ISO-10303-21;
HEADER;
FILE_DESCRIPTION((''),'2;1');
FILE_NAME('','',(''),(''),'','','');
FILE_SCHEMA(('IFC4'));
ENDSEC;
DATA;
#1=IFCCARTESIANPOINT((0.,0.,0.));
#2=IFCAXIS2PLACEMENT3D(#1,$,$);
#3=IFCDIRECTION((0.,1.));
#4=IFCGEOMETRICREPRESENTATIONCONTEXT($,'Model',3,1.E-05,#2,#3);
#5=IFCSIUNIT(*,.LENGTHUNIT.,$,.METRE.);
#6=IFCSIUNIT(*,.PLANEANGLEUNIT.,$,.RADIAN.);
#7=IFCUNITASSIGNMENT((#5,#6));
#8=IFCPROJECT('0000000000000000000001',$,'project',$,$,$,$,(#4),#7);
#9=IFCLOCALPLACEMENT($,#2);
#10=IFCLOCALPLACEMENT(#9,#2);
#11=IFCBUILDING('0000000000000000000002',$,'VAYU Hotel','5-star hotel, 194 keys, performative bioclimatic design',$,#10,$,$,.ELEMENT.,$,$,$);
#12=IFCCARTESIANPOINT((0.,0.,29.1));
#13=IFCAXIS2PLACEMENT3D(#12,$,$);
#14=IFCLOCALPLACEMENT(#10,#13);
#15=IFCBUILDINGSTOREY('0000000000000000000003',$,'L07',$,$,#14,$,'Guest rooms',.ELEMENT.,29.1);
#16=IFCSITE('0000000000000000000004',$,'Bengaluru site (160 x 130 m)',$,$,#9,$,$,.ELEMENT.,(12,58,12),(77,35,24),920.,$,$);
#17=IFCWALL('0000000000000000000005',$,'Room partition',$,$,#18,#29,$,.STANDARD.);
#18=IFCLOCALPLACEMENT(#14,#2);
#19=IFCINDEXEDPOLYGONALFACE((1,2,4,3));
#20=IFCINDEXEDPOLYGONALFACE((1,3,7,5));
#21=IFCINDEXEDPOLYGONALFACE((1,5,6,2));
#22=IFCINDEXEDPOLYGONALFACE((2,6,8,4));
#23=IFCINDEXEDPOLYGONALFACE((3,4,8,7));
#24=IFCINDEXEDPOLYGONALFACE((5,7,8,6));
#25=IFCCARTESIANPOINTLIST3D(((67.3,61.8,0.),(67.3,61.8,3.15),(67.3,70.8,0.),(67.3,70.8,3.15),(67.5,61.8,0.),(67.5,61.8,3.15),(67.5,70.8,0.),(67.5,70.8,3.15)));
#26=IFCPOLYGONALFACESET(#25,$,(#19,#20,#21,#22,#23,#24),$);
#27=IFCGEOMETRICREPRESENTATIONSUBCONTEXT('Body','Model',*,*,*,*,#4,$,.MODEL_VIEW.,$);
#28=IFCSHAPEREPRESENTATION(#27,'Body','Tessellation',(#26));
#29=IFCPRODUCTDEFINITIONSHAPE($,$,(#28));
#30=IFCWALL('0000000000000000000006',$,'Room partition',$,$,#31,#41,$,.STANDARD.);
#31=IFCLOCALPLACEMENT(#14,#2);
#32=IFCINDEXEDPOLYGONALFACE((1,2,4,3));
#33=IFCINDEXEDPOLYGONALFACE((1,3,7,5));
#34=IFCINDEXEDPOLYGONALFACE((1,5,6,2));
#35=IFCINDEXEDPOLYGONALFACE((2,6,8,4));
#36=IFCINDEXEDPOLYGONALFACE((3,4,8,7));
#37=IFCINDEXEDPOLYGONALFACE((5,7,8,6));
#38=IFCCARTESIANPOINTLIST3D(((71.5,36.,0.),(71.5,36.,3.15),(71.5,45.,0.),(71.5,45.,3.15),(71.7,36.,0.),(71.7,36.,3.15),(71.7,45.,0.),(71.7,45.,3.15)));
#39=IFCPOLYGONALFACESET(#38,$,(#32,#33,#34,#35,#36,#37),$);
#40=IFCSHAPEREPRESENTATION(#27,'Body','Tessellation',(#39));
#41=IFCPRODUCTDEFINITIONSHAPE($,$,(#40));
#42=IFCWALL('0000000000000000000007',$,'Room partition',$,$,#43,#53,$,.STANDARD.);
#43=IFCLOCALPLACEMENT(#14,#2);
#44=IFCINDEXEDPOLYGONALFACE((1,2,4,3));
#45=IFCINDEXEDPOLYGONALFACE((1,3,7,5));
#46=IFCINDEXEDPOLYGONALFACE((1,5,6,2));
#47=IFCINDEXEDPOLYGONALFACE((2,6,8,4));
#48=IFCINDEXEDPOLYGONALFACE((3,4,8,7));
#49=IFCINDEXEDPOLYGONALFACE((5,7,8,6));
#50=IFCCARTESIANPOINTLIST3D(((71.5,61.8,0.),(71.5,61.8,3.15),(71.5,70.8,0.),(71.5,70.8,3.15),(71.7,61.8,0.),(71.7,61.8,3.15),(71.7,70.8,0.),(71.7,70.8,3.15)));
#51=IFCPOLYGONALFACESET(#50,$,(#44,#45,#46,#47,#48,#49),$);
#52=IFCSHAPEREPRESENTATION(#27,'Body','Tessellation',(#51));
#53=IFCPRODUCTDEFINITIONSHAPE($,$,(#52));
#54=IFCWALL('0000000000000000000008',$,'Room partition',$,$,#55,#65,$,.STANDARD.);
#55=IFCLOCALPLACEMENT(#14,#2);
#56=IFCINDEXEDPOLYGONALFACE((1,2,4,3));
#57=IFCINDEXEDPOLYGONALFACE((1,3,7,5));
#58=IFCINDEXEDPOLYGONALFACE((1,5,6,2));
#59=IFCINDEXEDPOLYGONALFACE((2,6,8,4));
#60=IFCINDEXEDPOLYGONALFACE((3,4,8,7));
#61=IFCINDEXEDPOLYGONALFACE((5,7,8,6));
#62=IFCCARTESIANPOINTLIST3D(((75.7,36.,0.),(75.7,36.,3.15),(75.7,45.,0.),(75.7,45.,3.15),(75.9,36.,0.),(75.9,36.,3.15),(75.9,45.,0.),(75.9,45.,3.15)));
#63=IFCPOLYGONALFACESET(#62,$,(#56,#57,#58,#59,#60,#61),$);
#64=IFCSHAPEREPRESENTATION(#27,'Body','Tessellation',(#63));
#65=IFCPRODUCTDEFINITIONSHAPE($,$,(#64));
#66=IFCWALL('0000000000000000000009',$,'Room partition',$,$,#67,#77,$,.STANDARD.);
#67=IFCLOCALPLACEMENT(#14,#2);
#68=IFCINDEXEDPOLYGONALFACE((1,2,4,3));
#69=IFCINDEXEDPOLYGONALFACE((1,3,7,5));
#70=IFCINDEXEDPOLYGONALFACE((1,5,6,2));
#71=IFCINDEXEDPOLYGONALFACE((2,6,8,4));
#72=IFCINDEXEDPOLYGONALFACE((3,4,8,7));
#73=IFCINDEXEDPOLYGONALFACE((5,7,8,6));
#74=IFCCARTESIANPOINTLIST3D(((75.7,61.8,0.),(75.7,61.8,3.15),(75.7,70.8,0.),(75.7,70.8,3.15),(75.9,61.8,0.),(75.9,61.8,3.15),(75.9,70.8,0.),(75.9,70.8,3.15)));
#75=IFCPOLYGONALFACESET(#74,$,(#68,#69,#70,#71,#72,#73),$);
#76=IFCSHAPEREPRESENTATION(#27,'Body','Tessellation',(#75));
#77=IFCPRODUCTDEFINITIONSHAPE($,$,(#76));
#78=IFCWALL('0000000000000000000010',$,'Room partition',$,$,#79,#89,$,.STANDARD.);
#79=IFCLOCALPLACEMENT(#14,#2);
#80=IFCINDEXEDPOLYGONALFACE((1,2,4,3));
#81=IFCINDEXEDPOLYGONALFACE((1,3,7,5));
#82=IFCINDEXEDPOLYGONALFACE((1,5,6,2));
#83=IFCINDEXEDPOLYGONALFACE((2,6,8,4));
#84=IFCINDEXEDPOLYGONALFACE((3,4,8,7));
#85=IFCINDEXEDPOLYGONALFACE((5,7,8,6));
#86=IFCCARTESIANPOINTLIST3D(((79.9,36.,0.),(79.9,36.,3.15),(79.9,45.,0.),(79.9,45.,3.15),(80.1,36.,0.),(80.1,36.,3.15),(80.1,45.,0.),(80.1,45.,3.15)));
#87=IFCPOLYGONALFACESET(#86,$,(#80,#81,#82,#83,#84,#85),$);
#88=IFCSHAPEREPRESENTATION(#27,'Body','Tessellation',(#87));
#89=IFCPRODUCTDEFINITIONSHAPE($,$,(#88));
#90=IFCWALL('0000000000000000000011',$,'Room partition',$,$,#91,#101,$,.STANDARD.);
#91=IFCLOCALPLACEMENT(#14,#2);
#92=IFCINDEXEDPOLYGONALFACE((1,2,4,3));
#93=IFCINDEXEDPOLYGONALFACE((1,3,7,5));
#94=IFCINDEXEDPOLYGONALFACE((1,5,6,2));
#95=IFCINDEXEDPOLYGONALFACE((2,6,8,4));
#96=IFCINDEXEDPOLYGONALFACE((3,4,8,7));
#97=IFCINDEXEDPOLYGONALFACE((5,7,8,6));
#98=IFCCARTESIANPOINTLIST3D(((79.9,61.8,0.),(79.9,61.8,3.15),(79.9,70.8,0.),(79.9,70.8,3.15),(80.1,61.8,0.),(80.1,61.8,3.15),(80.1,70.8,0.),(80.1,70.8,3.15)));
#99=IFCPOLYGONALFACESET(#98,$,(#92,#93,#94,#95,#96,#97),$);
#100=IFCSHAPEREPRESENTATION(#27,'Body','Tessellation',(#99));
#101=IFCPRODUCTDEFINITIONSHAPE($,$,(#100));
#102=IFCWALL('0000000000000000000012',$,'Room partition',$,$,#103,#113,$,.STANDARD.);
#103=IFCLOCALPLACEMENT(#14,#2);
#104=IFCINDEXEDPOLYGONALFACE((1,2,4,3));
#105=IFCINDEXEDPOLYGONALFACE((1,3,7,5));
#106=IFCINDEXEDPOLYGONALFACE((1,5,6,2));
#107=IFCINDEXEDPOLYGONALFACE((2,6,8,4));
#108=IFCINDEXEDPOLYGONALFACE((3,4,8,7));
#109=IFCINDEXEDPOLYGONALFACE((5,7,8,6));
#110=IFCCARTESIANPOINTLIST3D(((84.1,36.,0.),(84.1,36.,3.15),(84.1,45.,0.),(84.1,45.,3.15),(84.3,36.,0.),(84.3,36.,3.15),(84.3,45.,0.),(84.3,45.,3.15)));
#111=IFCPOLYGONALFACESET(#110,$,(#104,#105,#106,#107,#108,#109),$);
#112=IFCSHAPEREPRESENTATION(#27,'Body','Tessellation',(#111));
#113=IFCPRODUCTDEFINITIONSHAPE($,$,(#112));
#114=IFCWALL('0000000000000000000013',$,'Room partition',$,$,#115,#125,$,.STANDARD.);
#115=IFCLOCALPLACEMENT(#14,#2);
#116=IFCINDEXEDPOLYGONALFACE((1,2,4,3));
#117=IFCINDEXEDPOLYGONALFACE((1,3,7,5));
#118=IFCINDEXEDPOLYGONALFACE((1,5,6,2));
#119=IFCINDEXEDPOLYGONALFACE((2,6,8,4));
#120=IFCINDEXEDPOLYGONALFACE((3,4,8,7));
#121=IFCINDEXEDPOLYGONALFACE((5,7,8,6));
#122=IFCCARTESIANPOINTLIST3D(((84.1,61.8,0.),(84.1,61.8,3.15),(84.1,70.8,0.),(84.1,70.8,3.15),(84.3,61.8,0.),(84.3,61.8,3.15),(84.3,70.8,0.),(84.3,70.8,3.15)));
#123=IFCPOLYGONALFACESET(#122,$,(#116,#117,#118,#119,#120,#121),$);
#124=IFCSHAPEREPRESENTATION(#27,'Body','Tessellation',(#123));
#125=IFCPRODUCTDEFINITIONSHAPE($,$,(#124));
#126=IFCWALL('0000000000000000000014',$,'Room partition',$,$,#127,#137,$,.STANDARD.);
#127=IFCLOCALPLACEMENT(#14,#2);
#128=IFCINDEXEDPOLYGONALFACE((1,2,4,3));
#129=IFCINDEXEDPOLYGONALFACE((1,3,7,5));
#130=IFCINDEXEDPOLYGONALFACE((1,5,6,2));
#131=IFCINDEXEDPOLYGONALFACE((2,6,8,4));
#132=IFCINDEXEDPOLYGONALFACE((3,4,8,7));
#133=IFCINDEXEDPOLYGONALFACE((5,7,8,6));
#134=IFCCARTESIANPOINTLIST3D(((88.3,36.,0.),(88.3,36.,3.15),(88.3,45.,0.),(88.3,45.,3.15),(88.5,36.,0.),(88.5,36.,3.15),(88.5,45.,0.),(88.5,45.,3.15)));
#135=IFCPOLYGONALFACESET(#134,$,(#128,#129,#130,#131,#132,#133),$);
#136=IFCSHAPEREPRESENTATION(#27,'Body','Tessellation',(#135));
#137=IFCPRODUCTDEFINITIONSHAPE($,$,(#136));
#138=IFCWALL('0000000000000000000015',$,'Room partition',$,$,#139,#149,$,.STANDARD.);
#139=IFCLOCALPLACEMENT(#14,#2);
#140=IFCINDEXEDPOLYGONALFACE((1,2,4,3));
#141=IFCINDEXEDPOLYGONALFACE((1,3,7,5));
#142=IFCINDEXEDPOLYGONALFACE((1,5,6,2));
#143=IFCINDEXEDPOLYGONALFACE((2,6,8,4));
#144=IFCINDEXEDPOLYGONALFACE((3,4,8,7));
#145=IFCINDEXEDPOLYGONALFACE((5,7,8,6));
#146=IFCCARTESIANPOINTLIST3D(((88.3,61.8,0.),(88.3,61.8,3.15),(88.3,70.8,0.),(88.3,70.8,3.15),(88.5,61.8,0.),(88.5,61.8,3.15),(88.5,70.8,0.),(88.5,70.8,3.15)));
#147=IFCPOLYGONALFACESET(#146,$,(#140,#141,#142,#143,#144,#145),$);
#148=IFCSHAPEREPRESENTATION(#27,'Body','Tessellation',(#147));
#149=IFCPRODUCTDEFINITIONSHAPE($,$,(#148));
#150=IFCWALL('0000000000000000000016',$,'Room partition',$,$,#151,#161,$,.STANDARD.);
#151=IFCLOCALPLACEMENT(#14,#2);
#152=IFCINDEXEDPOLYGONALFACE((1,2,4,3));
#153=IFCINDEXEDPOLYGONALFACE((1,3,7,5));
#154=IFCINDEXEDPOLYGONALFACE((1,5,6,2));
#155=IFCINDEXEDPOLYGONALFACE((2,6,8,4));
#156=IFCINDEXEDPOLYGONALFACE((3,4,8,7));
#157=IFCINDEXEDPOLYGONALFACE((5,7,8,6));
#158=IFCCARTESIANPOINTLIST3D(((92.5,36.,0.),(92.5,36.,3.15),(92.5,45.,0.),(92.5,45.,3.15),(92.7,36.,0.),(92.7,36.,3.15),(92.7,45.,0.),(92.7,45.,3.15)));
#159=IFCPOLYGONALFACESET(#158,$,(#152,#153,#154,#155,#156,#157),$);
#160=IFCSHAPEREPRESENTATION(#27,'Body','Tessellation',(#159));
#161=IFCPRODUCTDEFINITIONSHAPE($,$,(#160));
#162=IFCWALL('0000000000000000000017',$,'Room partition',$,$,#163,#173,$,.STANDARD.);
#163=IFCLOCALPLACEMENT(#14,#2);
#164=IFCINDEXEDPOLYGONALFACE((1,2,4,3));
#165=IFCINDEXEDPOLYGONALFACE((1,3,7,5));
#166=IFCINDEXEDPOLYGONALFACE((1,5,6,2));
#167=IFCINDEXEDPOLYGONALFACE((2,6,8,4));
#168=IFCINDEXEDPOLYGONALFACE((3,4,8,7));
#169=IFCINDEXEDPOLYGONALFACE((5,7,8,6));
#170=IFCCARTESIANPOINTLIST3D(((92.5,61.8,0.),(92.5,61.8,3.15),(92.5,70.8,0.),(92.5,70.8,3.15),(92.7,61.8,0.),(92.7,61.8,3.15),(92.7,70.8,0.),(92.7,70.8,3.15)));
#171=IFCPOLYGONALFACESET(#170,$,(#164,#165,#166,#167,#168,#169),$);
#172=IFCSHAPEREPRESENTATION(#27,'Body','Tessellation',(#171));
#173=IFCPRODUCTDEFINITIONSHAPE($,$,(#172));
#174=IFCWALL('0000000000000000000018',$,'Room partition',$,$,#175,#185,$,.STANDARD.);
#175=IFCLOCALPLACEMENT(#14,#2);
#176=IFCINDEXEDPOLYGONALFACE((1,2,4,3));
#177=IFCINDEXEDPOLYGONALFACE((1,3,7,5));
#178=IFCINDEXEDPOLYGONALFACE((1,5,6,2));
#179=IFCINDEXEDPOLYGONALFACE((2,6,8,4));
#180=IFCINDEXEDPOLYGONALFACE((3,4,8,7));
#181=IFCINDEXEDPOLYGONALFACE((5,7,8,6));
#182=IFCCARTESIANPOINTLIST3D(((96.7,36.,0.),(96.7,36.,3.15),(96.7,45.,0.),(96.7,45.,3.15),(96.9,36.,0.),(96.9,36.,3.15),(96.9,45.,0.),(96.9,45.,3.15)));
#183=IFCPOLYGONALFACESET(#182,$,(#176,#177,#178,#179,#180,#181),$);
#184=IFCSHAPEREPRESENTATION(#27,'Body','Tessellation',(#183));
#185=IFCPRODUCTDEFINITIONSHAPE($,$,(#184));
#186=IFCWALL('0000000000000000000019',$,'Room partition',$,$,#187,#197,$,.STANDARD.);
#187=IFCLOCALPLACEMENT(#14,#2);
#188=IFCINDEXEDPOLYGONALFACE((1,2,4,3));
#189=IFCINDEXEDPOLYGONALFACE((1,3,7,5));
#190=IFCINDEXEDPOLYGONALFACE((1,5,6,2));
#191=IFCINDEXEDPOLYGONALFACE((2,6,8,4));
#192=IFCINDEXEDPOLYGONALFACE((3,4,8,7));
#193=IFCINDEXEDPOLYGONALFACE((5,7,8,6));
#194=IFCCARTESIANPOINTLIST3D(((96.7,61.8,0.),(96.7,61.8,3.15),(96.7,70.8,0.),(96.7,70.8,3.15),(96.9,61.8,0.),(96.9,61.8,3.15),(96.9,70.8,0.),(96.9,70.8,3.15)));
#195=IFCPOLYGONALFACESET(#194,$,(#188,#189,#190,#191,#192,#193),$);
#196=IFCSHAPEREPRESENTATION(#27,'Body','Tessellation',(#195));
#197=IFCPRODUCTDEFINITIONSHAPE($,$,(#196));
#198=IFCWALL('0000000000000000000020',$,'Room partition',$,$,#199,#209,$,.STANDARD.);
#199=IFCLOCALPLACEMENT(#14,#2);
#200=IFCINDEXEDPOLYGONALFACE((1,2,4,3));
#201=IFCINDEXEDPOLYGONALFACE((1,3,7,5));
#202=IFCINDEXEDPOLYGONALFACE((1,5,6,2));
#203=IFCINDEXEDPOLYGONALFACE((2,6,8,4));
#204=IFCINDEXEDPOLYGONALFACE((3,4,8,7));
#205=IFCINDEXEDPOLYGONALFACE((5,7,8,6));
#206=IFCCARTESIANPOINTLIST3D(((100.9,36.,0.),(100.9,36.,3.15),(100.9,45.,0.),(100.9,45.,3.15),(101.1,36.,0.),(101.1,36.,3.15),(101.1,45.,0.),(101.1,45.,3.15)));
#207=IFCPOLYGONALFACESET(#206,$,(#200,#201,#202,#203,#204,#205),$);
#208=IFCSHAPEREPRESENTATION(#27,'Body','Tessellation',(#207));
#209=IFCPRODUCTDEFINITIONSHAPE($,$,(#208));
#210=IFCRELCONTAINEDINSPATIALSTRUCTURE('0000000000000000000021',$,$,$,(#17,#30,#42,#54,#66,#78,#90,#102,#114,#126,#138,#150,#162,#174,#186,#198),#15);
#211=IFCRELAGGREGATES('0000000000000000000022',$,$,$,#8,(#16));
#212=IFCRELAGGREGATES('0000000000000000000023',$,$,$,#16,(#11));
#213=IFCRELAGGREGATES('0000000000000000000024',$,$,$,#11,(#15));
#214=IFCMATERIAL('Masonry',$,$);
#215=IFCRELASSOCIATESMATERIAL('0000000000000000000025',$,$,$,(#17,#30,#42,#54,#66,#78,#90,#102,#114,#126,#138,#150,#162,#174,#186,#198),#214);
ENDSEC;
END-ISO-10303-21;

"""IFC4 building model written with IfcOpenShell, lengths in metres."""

from ifc_helpers import new_model, si_unit, direction, frame, origin, place, context, subcontext, project, spatial, polyline, outline, extrude, material, element, save


model = new_model("IFC4")

# Units and contexts
model_context = context("Model", 3, precision=1e-05, world=origin(), true_north=direction((0.0, 1.0)))
body_context = subcontext(model_context, "Body", "Model", "MODEL_VIEW")
ifc_project = project(units=[si_unit("LENGTHUNIT", "METRE"), si_unit("PLANEANGLEUNIT", "RADIAN")], contexts=[model_context])

# Site, building, storey
site_placement = place(None, origin())
site = spatial("IfcSite", under=ifc_project, at=site_placement, Name="Bengaluru site (160 x 130 m)", CompositionType="ELEMENT", RefLatitude=(12, 58, 12), RefLongitude=(77, 35, 24), RefElevation=920.0)
building_placement = place(site_placement, origin())
building = spatial("IfcBuilding", under=site, at=building_placement, Name="VAYU Hotel", Description="5-star hotel, 194 keys, performative bioclimatic design", CompositionType="ELEMENT")
storey_placement = place(building_placement, frame((0.0, 0.0, 29.1)))
storey = spatial("IfcBuildingStorey", under=building, at=storey_placement, Name="L07", LongName="Guest rooms", CompositionType="ELEMENT", Elevation=29.1)

# Walls
ifc_material_1 = material(Name="Masonry")
wall_1_placement = place(storey_placement, origin())
element("IfcWall", 1, at=wall_1_placement, inside=storey, material=ifc_material_1, Name="Room partition", PredefinedType="STANDARD", context=body_context, shape_type="SweptSolid", body=[
    extrude(outline(polyline([(67.3, 61.8), (67.3, 70.8), (67.5, 70.8), (67.5, 61.8), (67.3, 61.8)])), origin(), (0.0, 0.0, 1.0), 3.15),
])
wall_2_placement = place(storey_placement, origin())
element("IfcWall", 2, at=wall_2_placement, inside=storey, material=ifc_material_1, Name="Room partition", PredefinedType="STANDARD", context=body_context, shape_type="SweptSolid", body=[
    extrude(outline(polyline([(71.5, 36.0), (71.5, 45.0), (71.7, 45.0), (71.7, 36.0), (71.5, 36.0)])), origin(), (0.0, 0.0, 1.0), 3.15),
])
wall_3_placement = place(storey_placement, origin())
element("IfcWall", 3, at=wall_3_placement, inside=storey, material=ifc_material_1, Name="Room partition", PredefinedType="STANDARD", context=body_context, shape_type="SweptSolid", body=[
    extrude(outline(polyline([(71.5, 61.8), (71.5, 70.8), (71.7, 70.8), (71.7, 61.8), (71.5, 61.8)])), origin(), (0.0, 0.0, 1.0), 3.15),
])
wall_4_placement = place(storey_placement, origin())
element("IfcWall", 4, at=wall_4_placement, inside=storey, material=ifc_material_1, Name="Room partition", PredefinedType="STANDARD", context=body_context, shape_type="SweptSolid", body=[
    extrude(outline(polyline([(75.7, 36.0), (75.7, 45.0), (75.9, 45.0), (75.9, 36.0), (75.7, 36.0)])), origin(), (0.0, 0.0, 1.0), 3.15),
])
wall_5_placement = place(storey_placement, origin())
element("IfcWall", 5, at=wall_5_placement, inside=storey, material=ifc_material_1, Name="Room partition", PredefinedType="STANDARD", context=body_context, shape_type="SweptSolid", body=[
    extrude(outline(polyline([(75.7, 61.8), (75.7, 70.8), (75.9, 70.8), (75.9, 61.8), (75.7, 61.8)])), origin(), (0.0, 0.0, 1.0), 3.15),
])
wall_6_placement = place(storey_placement, origin())
element("IfcWall", 6, at=wall_6_placement, inside=storey, material=ifc_material_1, Name="Room partition", PredefinedType="STANDARD", context=body_context, shape_type="SweptSolid", body=[
    extrude(outline(polyline([(79.9, 36.0), (79.9, 45.0), (80.1, 45.0), (80.1, 36.0), (79.9, 36.0)])), origin(), (0.0, 0.0, 1.0), 3.15),
])
wall_7_placement = place(storey_placement, origin())
element("IfcWall", 7, at=wall_7_placement, inside=storey, material=ifc_material_1, Name="Room partition", PredefinedType="STANDARD", context=body_context, shape_type="SweptSolid", body=[
    extrude(outline(polyline([(79.9, 61.8), (79.9, 70.8), (80.1, 70.8), (80.1, 61.8), (79.9, 61.8)])), origin(), (0.0, 0.0, 1.0), 3.15),
])
wall_8_placement = place(storey_placement, origin())
element("IfcWall", 8, at=wall_8_placement, inside=storey, material=ifc_material_1, Name="Room partition", PredefinedType="STANDARD", context=body_context, shape_type="SweptSolid", body=[
    extrude(outline(polyline([(84.1, 36.0), (84.1, 45.0), (84.3, 45.0), (84.3, 36.0), (84.1, 36.0)])), origin(), (0.0, 0.0, 1.0), 3.15),
])
wall_9_placement = place(storey_placement, origin())
element("IfcWall", 9, at=wall_9_placement, inside=storey, material=ifc_material_1, Name="Room partition", PredefinedType="STANDARD", context=body_context, shape_type="SweptSolid", body=[
    extrude(outline(polyline([(84.1, 61.8), (84.1, 70.8), (84.3, 70.8), (84.3, 61.8), (84.1, 61.8)])), origin(), (0.0, 0.0, 1.0), 3.15),
])
wall_10_placement = place(storey_placement, origin())
element("IfcWall", 10, at=wall_10_placement, inside=storey, material=ifc_material_1, Name="Room partition", PredefinedType="STANDARD", context=body_context, shape_type="SweptSolid", body=[
    extrude(outline(polyline([(88.3, 36.0), (88.3, 45.0), (88.5, 45.0), (88.5, 36.0), (88.3, 36.0)])), origin(), (0.0, 0.0, 1.0), 3.15),
])
wall_11_placement = place(storey_placement, origin())
element("IfcWall", 11, at=wall_11_placement, inside=storey, material=ifc_material_1, Name="Room partition", PredefinedType="STANDARD", context=body_context, shape_type="SweptSolid", body=[
    extrude(outline(polyline([(88.3, 61.8), (88.3, 70.8), (88.5, 70.8), (88.5, 61.8), (88.3, 61.8)])), origin(), (0.0, 0.0, 1.0), 3.15),
])
wall_12_placement = place(storey_placement, origin())
element("IfcWall", 12, at=wall_12_placement, inside=storey, material=ifc_material_1, Name="Room partition", PredefinedType="STANDARD", context=body_context, shape_type="SweptSolid", body=[
    extrude(outline(polyline([(92.5, 36.0), (92.5, 45.0), (92.7, 45.0), (92.7, 36.0), (92.5, 36.0)])), origin(), (0.0, 0.0, 1.0), 3.15),
])
wall_13_placement = place(storey_placement, origin())
element("IfcWall", 13, at=wall_13_placement, inside=storey, material=ifc_material_1, Name="Room partition", PredefinedType="STANDARD", context=body_context, shape_type="SweptSolid", body=[
    extrude(outline(polyline([(92.5, 61.8), (92.5, 70.8), (92.7, 70.8), (92.7, 61.8), (92.5, 61.8)])), origin(), (0.0, 0.0, 1.0), 3.15),
])
wall_14_placement = place(storey_placement, origin())
element("IfcWall", 14, at=wall_14_placement, inside=storey, material=ifc_material_1, Name="Room partition", PredefinedType="STANDARD", context=body_context, shape_type="SweptSolid", body=[
    extrude(outline(polyline([(96.7, 36.0), (96.7, 45.0), (96.9, 45.0), (96.9, 36.0), (96.7, 36.0)])), origin(), (0.0, 0.0, 1.0), 3.15),
])
wall_15_placement = place(storey_placement, origin())
element("IfcWall", 15, at=wall_15_placement, inside=storey, material=ifc_material_1, Name="Room partition", PredefinedType="STANDARD", context=body_context, shape_type="SweptSolid", body=[
    extrude(outline(polyline([(96.7, 61.8), (96.7, 70.8), (96.9, 70.8), (96.9, 61.8), (96.7, 61.8)])), origin(), (0.0, 0.0, 1.0), 3.15),
])
wall_16_placement = place(storey_placement, origin())
element("IfcWall", 16, at=wall_16_placement, inside=storey, material=ifc_material_1, Name="Room partition", PredefinedType="STANDARD", context=body_context, shape_type="SweptSolid", body=[
    extrude(outline(polyline([(100.9, 36.0), (100.9, 45.0), (101.1, 45.0), (101.1, 36.0), (100.9, 36.0)])), origin(), (0.0, 0.0, 1.0), 3.15),
])

save(model, "model.ifc")
